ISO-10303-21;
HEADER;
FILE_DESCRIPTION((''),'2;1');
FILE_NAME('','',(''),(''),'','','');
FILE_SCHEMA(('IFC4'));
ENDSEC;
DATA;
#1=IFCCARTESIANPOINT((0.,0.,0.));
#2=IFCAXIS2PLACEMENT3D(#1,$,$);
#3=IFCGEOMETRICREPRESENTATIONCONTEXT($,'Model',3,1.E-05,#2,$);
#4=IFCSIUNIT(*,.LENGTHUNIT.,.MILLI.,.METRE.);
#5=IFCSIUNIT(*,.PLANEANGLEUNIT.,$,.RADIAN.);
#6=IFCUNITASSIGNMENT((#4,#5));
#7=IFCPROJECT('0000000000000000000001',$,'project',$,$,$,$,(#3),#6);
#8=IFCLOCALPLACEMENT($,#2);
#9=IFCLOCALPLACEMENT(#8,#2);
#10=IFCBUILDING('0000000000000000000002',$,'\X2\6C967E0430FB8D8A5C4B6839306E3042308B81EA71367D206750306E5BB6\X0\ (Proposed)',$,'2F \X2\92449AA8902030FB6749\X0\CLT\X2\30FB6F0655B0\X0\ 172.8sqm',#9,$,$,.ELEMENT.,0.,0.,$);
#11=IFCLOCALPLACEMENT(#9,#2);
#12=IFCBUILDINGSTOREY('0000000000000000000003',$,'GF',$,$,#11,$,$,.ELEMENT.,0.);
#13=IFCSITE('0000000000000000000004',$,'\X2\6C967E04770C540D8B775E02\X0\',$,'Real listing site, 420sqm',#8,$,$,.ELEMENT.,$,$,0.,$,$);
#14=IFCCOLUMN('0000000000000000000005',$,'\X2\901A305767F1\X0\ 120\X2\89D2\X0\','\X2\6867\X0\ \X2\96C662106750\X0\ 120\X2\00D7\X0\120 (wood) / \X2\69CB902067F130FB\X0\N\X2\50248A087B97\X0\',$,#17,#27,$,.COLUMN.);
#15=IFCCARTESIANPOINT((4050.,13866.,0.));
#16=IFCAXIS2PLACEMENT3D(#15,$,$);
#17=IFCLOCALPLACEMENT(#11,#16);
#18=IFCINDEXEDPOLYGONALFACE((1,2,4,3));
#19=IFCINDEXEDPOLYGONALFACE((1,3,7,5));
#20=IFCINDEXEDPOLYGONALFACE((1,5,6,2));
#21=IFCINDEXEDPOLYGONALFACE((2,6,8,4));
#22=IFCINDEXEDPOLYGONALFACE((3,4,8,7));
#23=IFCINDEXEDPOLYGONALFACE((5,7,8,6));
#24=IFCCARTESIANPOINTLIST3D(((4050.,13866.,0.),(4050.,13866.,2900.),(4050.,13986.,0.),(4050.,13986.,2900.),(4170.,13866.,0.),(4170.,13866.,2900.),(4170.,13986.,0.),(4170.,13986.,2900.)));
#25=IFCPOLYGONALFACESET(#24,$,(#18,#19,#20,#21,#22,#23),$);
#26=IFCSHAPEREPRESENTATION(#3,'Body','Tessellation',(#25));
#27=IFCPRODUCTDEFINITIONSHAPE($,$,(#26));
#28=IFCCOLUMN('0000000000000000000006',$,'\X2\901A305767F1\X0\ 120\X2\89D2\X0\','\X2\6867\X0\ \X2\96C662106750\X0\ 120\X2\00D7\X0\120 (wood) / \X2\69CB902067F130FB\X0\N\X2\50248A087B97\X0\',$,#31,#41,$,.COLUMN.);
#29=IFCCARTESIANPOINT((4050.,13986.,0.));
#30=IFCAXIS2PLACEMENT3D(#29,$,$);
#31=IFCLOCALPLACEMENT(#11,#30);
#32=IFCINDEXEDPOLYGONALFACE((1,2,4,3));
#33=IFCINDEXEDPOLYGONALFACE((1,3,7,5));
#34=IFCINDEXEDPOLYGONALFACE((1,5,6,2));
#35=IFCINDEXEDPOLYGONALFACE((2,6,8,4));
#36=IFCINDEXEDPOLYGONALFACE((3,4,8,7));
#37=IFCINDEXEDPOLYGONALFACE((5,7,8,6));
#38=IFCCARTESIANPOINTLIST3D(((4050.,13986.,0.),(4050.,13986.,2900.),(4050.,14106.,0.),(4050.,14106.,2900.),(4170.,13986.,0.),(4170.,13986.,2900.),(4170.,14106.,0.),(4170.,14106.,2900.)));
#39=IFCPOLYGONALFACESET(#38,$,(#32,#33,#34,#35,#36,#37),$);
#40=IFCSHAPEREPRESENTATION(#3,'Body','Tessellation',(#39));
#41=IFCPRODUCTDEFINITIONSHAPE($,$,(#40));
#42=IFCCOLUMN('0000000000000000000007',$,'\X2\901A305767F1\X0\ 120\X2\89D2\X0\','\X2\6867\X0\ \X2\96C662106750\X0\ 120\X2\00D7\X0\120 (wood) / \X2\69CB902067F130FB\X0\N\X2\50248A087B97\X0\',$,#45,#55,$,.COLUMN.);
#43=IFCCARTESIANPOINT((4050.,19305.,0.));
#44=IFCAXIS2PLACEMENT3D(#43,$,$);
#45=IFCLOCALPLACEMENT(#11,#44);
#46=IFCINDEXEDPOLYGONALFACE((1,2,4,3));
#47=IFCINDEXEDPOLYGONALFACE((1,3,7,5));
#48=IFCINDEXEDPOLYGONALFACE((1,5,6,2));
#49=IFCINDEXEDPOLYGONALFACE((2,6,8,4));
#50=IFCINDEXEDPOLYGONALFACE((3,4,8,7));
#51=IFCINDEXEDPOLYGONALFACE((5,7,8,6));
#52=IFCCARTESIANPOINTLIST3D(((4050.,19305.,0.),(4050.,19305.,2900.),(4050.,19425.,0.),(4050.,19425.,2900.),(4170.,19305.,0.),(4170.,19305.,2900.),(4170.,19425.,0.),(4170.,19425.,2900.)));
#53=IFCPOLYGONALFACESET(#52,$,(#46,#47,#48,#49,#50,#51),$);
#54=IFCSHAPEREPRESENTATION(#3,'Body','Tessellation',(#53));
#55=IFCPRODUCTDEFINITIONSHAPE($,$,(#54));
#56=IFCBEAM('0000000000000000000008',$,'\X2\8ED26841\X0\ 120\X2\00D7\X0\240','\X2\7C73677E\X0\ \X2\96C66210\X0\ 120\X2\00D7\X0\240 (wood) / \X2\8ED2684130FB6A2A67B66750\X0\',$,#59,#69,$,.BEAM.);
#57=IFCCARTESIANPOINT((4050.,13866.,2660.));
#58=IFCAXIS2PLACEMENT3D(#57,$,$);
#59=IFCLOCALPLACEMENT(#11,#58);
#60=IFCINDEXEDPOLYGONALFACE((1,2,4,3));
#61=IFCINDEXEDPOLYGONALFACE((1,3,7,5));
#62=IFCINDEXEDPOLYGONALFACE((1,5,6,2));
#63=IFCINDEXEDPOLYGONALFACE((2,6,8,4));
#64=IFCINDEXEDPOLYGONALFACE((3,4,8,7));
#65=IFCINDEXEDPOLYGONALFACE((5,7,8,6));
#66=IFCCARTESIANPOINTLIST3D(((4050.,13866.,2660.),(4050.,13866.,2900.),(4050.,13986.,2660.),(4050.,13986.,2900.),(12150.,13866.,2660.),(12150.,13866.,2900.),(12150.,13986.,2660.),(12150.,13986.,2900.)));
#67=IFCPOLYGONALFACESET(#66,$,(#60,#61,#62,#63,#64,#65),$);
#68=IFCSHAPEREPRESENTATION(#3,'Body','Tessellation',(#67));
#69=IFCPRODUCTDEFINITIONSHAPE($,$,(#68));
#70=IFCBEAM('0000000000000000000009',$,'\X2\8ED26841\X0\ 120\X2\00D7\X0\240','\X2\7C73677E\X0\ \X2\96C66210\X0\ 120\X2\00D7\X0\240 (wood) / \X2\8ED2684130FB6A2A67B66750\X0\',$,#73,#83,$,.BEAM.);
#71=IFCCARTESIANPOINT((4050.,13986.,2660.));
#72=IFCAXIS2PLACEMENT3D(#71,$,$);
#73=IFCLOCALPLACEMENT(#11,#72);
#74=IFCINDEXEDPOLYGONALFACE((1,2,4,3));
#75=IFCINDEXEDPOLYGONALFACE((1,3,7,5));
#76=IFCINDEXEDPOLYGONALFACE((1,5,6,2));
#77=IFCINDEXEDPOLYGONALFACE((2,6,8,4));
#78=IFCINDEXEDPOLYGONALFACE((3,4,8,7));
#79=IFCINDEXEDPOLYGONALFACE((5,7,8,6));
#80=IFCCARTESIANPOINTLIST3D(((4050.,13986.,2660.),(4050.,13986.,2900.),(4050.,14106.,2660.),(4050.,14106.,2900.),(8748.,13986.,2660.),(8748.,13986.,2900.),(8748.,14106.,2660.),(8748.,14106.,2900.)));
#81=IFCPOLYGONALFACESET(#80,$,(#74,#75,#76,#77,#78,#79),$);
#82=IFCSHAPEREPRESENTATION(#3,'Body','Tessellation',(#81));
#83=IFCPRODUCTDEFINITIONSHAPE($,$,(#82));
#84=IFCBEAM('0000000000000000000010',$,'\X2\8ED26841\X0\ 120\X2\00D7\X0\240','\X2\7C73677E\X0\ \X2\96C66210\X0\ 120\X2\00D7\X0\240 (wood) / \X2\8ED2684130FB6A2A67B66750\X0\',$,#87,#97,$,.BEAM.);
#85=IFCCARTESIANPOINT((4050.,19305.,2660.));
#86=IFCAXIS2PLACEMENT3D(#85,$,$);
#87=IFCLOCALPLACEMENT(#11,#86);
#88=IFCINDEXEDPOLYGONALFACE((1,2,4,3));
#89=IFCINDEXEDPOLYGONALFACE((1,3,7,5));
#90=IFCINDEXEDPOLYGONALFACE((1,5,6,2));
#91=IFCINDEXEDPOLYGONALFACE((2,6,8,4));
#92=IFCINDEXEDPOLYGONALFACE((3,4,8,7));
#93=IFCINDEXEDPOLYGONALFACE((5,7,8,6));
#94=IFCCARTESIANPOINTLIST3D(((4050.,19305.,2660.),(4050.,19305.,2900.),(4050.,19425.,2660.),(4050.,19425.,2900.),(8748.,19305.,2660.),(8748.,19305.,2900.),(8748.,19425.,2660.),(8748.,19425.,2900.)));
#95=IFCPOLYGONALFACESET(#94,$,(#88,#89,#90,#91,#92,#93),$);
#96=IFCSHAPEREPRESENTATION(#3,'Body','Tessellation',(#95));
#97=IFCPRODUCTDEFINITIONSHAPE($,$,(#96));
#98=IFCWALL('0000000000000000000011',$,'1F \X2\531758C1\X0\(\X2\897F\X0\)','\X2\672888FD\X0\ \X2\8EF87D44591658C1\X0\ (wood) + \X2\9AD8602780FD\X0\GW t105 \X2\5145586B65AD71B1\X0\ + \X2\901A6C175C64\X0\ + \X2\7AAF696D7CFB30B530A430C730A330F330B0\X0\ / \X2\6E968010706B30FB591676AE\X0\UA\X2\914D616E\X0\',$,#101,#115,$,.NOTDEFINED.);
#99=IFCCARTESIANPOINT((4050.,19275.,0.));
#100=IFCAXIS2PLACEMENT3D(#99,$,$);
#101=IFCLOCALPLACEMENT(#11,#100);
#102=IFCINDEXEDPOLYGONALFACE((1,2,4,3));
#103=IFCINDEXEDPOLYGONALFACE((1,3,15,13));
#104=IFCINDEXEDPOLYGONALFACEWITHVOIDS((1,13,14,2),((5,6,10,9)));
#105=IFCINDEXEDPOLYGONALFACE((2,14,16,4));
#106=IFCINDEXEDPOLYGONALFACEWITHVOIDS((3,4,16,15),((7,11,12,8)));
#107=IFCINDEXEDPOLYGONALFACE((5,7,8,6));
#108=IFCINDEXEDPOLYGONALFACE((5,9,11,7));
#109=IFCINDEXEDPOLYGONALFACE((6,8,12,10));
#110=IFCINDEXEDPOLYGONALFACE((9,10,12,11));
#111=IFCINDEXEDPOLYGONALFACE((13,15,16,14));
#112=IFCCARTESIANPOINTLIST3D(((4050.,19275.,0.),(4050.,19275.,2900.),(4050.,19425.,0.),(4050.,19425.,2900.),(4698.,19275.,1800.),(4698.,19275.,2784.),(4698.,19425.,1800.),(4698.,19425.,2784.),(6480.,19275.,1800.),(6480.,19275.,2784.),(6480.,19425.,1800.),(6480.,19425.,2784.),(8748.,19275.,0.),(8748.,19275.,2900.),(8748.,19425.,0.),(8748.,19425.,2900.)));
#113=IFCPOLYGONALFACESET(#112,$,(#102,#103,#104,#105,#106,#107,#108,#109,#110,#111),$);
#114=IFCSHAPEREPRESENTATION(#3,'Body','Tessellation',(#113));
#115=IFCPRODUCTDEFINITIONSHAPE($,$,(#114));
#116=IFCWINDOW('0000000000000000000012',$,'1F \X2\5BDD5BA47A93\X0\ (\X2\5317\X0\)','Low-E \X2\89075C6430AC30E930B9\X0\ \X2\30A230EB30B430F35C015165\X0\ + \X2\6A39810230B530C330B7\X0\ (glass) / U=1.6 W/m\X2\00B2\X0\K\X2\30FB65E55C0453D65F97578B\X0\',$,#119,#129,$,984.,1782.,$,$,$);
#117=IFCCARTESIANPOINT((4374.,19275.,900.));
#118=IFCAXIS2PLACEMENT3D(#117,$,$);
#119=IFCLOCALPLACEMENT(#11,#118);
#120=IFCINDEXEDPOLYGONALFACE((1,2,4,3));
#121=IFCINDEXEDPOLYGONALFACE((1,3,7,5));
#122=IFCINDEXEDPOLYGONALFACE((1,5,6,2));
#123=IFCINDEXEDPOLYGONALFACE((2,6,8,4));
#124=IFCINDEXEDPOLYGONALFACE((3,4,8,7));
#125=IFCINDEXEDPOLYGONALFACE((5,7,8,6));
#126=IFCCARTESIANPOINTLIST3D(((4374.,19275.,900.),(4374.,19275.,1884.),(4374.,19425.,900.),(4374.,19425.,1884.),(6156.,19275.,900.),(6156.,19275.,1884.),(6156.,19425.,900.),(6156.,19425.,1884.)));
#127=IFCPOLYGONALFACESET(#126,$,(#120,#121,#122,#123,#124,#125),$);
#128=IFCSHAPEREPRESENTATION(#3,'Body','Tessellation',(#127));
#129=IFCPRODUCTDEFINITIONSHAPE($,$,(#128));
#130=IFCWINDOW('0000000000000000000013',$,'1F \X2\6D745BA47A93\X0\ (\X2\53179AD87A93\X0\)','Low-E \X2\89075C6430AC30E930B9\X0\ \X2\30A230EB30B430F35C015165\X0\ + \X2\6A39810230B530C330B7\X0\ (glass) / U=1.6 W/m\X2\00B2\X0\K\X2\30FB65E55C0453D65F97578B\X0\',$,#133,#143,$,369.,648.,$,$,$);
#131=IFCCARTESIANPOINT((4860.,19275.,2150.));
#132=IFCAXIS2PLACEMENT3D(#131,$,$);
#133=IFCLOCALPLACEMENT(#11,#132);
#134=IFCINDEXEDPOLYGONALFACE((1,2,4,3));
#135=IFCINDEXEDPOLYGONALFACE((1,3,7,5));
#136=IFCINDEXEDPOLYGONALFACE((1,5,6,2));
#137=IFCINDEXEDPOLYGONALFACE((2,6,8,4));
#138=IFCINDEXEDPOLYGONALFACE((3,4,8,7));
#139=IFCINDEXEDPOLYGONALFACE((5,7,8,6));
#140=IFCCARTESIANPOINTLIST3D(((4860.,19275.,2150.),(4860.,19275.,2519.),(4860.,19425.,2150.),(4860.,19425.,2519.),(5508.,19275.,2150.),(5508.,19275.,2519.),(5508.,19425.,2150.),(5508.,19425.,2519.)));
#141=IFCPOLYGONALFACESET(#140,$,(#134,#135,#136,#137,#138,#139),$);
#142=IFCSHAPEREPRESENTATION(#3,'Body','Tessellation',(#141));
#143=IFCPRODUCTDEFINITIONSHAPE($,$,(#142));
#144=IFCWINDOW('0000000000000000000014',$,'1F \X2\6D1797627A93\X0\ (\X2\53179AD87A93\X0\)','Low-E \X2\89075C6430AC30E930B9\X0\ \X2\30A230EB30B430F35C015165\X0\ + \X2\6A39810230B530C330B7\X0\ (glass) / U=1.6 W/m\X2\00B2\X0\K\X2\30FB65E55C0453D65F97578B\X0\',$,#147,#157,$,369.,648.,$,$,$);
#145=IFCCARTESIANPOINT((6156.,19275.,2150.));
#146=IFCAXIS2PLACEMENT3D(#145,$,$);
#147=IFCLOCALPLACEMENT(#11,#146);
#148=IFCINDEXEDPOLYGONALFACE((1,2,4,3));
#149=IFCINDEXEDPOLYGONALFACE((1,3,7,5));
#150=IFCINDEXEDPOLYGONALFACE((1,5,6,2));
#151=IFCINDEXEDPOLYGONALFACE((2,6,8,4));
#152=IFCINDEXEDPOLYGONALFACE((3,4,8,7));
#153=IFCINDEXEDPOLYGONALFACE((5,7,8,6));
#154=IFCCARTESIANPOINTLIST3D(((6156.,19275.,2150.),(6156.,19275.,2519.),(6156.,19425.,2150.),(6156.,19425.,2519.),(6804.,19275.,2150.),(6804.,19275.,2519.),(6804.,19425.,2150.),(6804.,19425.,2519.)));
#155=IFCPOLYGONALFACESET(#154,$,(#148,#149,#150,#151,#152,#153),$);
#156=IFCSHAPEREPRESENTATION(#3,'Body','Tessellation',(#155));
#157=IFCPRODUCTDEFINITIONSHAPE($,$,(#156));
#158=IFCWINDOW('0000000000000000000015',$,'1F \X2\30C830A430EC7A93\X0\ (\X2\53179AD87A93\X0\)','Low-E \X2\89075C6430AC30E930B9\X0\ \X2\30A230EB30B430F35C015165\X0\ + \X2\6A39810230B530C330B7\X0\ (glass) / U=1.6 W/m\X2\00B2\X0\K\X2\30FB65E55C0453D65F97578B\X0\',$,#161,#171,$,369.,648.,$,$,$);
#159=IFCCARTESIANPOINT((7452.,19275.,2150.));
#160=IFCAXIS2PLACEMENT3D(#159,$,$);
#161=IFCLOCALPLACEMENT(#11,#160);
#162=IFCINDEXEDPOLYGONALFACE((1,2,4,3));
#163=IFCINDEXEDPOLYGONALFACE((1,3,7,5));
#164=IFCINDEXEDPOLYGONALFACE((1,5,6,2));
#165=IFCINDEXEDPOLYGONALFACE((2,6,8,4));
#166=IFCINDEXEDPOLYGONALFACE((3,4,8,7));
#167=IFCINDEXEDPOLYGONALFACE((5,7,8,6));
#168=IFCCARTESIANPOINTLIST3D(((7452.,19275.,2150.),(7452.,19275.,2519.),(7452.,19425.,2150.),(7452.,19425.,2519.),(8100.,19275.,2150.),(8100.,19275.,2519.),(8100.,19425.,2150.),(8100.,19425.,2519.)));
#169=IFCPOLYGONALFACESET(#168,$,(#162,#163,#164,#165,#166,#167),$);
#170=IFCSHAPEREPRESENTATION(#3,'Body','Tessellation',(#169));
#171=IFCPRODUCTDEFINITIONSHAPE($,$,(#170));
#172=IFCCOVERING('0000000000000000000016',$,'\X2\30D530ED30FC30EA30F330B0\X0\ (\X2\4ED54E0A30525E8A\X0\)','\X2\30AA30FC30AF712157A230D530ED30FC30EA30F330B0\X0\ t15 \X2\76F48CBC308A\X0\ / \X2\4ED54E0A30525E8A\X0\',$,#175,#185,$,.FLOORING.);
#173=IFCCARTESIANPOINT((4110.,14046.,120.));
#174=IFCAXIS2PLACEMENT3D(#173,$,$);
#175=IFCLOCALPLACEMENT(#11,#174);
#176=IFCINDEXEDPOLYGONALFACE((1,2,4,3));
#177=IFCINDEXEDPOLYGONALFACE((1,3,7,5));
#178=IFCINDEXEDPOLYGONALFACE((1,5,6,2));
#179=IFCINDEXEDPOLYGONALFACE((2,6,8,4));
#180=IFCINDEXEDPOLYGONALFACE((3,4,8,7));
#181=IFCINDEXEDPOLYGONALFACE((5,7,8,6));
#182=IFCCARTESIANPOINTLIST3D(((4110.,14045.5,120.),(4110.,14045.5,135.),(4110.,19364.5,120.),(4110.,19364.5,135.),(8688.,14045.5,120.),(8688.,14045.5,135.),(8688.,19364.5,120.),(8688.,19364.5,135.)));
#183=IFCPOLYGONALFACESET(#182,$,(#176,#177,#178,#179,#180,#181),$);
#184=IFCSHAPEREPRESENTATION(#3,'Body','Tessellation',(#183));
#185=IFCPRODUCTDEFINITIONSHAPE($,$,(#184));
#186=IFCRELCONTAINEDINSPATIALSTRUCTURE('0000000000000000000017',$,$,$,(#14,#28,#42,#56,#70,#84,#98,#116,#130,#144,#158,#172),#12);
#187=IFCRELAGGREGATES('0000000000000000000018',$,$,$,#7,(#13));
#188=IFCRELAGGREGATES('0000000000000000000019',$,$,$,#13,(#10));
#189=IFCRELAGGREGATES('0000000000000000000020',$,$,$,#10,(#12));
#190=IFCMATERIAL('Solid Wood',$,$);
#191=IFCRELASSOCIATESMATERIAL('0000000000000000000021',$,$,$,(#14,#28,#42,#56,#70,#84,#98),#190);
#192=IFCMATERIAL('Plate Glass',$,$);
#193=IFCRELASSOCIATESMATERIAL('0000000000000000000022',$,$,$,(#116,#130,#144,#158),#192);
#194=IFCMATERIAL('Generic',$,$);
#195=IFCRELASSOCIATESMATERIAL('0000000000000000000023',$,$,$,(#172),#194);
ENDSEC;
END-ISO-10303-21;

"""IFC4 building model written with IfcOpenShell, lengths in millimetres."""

from ifc_helpers import new_model, si_unit, frame, frame_2d, origin, place, context, project, spatial, rectangle, extrude, material, element, fill, save


model = new_model("IFC4")

# Units and contexts
model_context = context("Model", 3, precision=1e-05, world=origin())
ifc_project = project(units=[si_unit("LENGTHUNIT", "METRE", prefix="MILLI"), si_unit("PLANEANGLEUNIT", "RADIAN")], contexts=[model_context])

# Site, building, storey
site_placement = place(None, origin())
site = spatial("IfcSite", under=ifc_project, at=site_placement, Name="沖縄県名護市", ObjectType="Real listing site, 420sqm", CompositionType="ELEMENT", RefElevation=0.0)
building_placement = place(site_placement, origin())
building = spatial("IfcBuilding", under=site, at=building_placement, Name="沖縄・越屋根のある自然素材の家 (Proposed)", ObjectType="2F 鉄骨造・杉CLT・漆喰 172.8sqm", CompositionType="ELEMENT", ElevationOfRefHeight=0.0, ElevationOfTerrain=0.0)
storey_placement = place(building_placement, origin())
storey = spatial("IfcBuildingStorey", under=building, at=storey_placement, Name="GF", CompositionType="ELEMENT", Elevation=0.0)

# Columns
ifc_material_1 = material(Name="Solid Wood")
column_1_placement = place(storey_placement, frame((4050.0, 13866.0, 0.0)))
element("IfcColumn", 1, at=column_1_placement, inside=storey, material=ifc_material_1, Name="通し柱 120角", Description="桧 集成材 120×120 (wood) / 構造柱・N値計算", PredefinedType="COLUMN", context=model_context, shape_type="SweptSolid", body=[
    extrude(rectangle(XDim=120.0, YDim=120.0, at=frame_2d((60.0, 60.0))), frame((4050.0, 13866.0, 0.0)), (0.0, 0.0, 1.0), 2900.0),
])
column_2_placement = place(storey_placement, frame((4050.0, 13986.0, 0.0)))
element("IfcColumn", 2, at=column_2_placement, inside=storey, material=ifc_material_1, Name="通し柱 120角", Description="桧 集成材 120×120 (wood) / 構造柱・N値計算", PredefinedType="COLUMN", context=model_context, shape_type="SweptSolid", body=[
    extrude(rectangle(XDim=120.0, YDim=120.0, at=frame_2d((60.0, 60.0))), frame((4050.0, 13986.0, 0.0)), (0.0, 0.0, 1.0), 2900.0),
])
column_3_placement = place(storey_placement, frame((4050.0, 19305.0, 0.0)))
element("IfcColumn", 3, at=column_3_placement, inside=storey, material=ifc_material_1, Name="通し柱 120角", Description="桧 集成材 120×120 (wood) / 構造柱・N値計算", PredefinedType="COLUMN", context=model_context, shape_type="SweptSolid", body=[
    extrude(rectangle(XDim=120.0, YDim=120.0, at=frame_2d((60.0, 60.0))), frame((4050.0, 19305.0, 0.0)), (0.0, 0.0, 1.0), 2900.0),
])

# Beams
beam_1_placement = place(storey_placement, frame((4050.0, 13866.0, 2660.0)))
element("IfcBeam", 4, at=beam_1_placement, inside=storey, material=ifc_material_1, Name="軒桁 120×240", Description="米松 集成 120×240 (wood) / 軒桁・横架材", PredefinedType="BEAM", context=model_context, shape_type="SweptSolid", body=[
    extrude(rectangle(XDim=8100.0, YDim=120.0, at=frame_2d((4050.0, 60.0))), frame((4050.0, 13866.0, 2660.0)), (0.0, 0.0, 1.0), 240.0),
])
beam_2_placement = place(storey_placement, frame((4050.0, 13986.0, 2660.0)))
element("IfcBeam", 5, at=beam_2_placement, inside=storey, material=ifc_material_1, Name="軒桁 120×240", Description="米松 集成 120×240 (wood) / 軒桁・横架材", PredefinedType="BEAM", context=model_context, shape_type="SweptSolid", body=[
    extrude(rectangle(XDim=4698.0, YDim=120.0, at=frame_2d((2349.0, 60.0))), frame((4050.0, 13986.0, 2660.0)), (0.0, 0.0, 1.0), 240.0),
])
beam_3_placement = place(storey_placement, frame((4050.0, 19305.0, 2660.0)))
element("IfcBeam", 6, at=beam_3_placement, inside=storey, material=ifc_material_1, Name="軒桁 120×240", Description="米松 集成 120×240 (wood) / 軒桁・横架材", PredefinedType="BEAM", context=model_context, shape_type="SweptSolid", body=[
    extrude(rectangle(XDim=4698.0, YDim=120.0, at=frame_2d((2349.0, 60.0))), frame((4050.0, 19305.0, 2660.0)), (0.0, 0.0, 1.0), 240.0),
])

# Wall, openings, windows
wall_1_placement = place(storey_placement, frame((4050.0, 19275.0, 0.0)))
wall_1 = element("IfcWall", 7, at=wall_1_placement, inside=storey, material=ifc_material_1, Name="1F 北壁(西)", Description="木製 軸組外壁 (wood) + 高性能GW t105 充填断熱 + 通気層 + 窯業系サイディング / 準耐火・外皮UA配慮", PredefinedType="NOTDEFINED", context=model_context, shape_type="SweptSolid", body=[
    extrude(rectangle(XDim=4698.0, YDim=150.0, at=frame_2d((2349.0, 75.0))), frame((4050.0, 19275.0, 0.0)), (0.0, 0.0, 1.0), 2900.0),
])
opening_1_placement = place(storey_placement, frame((4374.0, 19275.0, 900.0)))
opening_1 = element("IfcOpeningElement", 8, at=opening_1_placement, cuts=wall_1, PredefinedType="NOTDEFINED", context=model_context, shape_type="SweptSolid", body=[
    extrude(rectangle(XDim=1782.0, YDim=150.0, at=frame_2d((891.0, 75.0))), frame((4374.0, 19275.0, 900.0)), (0.0, 0.0, 1.0), 984.0),
])
opening_2_placement = place(storey_placement, frame((4860.0, 19275.0, 2150.0)))
opening_2 = element("IfcOpeningElement", 9, at=opening_2_placement, cuts=wall_1, PredefinedType="NOTDEFINED", context=model_context, shape_type="SweptSolid", body=[
    extrude(rectangle(XDim=648.0, YDim=150.0, at=frame_2d((324.0, 75.0))), frame((4860.0, 19275.0, 2150.0)), (0.0, 0.0, 1.0), 369.0),
])
opening_3_placement = place(storey_placement, frame((6156.0, 19275.0, 2150.0)))
opening_3 = element("IfcOpeningElement", 10, at=opening_3_placement, cuts=wall_1, PredefinedType="NOTDEFINED", context=model_context, shape_type="SweptSolid", body=[
    extrude(rectangle(XDim=648.0, YDim=150.0, at=frame_2d((324.0, 75.0))), frame((6156.0, 19275.0, 2150.0)), (0.0, 0.0, 1.0), 369.0),
])
opening_4_placement = place(storey_placement, frame((7452.0, 19275.0, 2150.0)))
opening_4 = element("IfcOpeningElement", 11, at=opening_4_placement, cuts=wall_1, PredefinedType="NOTDEFINED", context=model_context, shape_type="SweptSolid", body=[
    extrude(rectangle(XDim=648.0, YDim=150.0, at=frame_2d((324.0, 75.0))), frame((7452.0, 19275.0, 2150.0)), (0.0, 0.0, 1.0), 369.0),
])
ifc_material_2 = material(Name="Plate Glass")
window_1_placement = place(storey_placement, frame((4374.0, 19275.0, 900.0)))
window_1 = element("IfcWindow", 12, at=window_1_placement, inside=storey, material=ifc_material_2, Name="1F 寝室窓 (北)", Description="Low-E 複層ガラス アルゴン封入 + 樹脂サッシ (glass) / U=1.6 W/m²K・日射取得型", OverallHeight=984.0, OverallWidth=1782.0, context=model_context, shape_type="SweptSolid", body=[
    extrude(rectangle(XDim=1782.0, YDim=150.0, at=frame_2d((891.0, 75.0))), frame((4374.0, 19275.0, 900.0)), (0.0, 0.0, 1.0), 984.0),
])
fill(opening_1, window_1)
window_2_placement = place(storey_placement, frame((4860.0, 19275.0, 2150.0)))
window_2 = element("IfcWindow", 13, at=window_2_placement, inside=storey, material=ifc_material_2, Name="1F 浴室窓 (北高窓)", Description="Low-E 複層ガラス アルゴン封入 + 樹脂サッシ (glass) / U=1.6 W/m²K・日射取得型", OverallHeight=369.0, OverallWidth=648.0, context=model_context, shape_type="SweptSolid", body=[
    extrude(rectangle(XDim=648.0, YDim=150.0, at=frame_2d((324.0, 75.0))), frame((4860.0, 19275.0, 2150.0)), (0.0, 0.0, 1.0), 369.0),
])
fill(opening_2, window_2)
window_3_placement = place(storey_placement, frame((6156.0, 19275.0, 2150.0)))
window_3 = element("IfcWindow", 14, at=window_3_placement, inside=storey, material=ifc_material_2, Name="1F 洗面窓 (北高窓)", Description="Low-E 複層ガラス アルゴン封入 + 樹脂サッシ (glass) / U=1.6 W/m²K・日射取得型", OverallHeight=369.0, OverallWidth=648.0, context=model_context, shape_type="SweptSolid", body=[
    extrude(rectangle(XDim=648.0, YDim=150.0, at=frame_2d((324.0, 75.0))), frame((6156.0, 19275.0, 2150.0)), (0.0, 0.0, 1.0), 369.0),
])
fill(opening_3, window_3)
window_4_placement = place(storey_placement, frame((7452.0, 19275.0, 2150.0)))
window_4 = element("IfcWindow", 15, at=window_4_placement, inside=storey, material=ifc_material_2, Name="1F トイレ窓 (北高窓)", Description="Low-E 複層ガラス アルゴン封入 + 樹脂サッシ (glass) / U=1.6 W/m²K・日射取得型", OverallHeight=369.0, OverallWidth=648.0, context=model_context, shape_type="SweptSolid", body=[
    extrude(rectangle(XDim=648.0, YDim=150.0, at=frame_2d((324.0, 75.0))), frame((7452.0, 19275.0, 2150.0)), (0.0, 0.0, 1.0), 369.0),
])
fill(opening_4, window_4)

# Covering
ifc_material_3 = material(Name="Generic")
covering_placement = place(storey_placement, frame((4110.0, 14046.0, 120.0)))
element("IfcCovering", 16, at=covering_placement, inside=storey, material=ifc_material_3, Name="フローリング (仕上げ床)", Description="オーク無垢フローリング t15 直貼り / 仕上げ床", PredefinedType="FLOORING", context=model_context, shape_type="SweptSolid", body=[
    extrude(rectangle(XDim=4578.0, YDim=5319.0, at=frame_2d((2289.0, 2659.0))), frame((4110.0, 14046.0, 120.0)), (0.0, 0.0, 1.0), 15.0),
])

save(model, "model.ifc")
